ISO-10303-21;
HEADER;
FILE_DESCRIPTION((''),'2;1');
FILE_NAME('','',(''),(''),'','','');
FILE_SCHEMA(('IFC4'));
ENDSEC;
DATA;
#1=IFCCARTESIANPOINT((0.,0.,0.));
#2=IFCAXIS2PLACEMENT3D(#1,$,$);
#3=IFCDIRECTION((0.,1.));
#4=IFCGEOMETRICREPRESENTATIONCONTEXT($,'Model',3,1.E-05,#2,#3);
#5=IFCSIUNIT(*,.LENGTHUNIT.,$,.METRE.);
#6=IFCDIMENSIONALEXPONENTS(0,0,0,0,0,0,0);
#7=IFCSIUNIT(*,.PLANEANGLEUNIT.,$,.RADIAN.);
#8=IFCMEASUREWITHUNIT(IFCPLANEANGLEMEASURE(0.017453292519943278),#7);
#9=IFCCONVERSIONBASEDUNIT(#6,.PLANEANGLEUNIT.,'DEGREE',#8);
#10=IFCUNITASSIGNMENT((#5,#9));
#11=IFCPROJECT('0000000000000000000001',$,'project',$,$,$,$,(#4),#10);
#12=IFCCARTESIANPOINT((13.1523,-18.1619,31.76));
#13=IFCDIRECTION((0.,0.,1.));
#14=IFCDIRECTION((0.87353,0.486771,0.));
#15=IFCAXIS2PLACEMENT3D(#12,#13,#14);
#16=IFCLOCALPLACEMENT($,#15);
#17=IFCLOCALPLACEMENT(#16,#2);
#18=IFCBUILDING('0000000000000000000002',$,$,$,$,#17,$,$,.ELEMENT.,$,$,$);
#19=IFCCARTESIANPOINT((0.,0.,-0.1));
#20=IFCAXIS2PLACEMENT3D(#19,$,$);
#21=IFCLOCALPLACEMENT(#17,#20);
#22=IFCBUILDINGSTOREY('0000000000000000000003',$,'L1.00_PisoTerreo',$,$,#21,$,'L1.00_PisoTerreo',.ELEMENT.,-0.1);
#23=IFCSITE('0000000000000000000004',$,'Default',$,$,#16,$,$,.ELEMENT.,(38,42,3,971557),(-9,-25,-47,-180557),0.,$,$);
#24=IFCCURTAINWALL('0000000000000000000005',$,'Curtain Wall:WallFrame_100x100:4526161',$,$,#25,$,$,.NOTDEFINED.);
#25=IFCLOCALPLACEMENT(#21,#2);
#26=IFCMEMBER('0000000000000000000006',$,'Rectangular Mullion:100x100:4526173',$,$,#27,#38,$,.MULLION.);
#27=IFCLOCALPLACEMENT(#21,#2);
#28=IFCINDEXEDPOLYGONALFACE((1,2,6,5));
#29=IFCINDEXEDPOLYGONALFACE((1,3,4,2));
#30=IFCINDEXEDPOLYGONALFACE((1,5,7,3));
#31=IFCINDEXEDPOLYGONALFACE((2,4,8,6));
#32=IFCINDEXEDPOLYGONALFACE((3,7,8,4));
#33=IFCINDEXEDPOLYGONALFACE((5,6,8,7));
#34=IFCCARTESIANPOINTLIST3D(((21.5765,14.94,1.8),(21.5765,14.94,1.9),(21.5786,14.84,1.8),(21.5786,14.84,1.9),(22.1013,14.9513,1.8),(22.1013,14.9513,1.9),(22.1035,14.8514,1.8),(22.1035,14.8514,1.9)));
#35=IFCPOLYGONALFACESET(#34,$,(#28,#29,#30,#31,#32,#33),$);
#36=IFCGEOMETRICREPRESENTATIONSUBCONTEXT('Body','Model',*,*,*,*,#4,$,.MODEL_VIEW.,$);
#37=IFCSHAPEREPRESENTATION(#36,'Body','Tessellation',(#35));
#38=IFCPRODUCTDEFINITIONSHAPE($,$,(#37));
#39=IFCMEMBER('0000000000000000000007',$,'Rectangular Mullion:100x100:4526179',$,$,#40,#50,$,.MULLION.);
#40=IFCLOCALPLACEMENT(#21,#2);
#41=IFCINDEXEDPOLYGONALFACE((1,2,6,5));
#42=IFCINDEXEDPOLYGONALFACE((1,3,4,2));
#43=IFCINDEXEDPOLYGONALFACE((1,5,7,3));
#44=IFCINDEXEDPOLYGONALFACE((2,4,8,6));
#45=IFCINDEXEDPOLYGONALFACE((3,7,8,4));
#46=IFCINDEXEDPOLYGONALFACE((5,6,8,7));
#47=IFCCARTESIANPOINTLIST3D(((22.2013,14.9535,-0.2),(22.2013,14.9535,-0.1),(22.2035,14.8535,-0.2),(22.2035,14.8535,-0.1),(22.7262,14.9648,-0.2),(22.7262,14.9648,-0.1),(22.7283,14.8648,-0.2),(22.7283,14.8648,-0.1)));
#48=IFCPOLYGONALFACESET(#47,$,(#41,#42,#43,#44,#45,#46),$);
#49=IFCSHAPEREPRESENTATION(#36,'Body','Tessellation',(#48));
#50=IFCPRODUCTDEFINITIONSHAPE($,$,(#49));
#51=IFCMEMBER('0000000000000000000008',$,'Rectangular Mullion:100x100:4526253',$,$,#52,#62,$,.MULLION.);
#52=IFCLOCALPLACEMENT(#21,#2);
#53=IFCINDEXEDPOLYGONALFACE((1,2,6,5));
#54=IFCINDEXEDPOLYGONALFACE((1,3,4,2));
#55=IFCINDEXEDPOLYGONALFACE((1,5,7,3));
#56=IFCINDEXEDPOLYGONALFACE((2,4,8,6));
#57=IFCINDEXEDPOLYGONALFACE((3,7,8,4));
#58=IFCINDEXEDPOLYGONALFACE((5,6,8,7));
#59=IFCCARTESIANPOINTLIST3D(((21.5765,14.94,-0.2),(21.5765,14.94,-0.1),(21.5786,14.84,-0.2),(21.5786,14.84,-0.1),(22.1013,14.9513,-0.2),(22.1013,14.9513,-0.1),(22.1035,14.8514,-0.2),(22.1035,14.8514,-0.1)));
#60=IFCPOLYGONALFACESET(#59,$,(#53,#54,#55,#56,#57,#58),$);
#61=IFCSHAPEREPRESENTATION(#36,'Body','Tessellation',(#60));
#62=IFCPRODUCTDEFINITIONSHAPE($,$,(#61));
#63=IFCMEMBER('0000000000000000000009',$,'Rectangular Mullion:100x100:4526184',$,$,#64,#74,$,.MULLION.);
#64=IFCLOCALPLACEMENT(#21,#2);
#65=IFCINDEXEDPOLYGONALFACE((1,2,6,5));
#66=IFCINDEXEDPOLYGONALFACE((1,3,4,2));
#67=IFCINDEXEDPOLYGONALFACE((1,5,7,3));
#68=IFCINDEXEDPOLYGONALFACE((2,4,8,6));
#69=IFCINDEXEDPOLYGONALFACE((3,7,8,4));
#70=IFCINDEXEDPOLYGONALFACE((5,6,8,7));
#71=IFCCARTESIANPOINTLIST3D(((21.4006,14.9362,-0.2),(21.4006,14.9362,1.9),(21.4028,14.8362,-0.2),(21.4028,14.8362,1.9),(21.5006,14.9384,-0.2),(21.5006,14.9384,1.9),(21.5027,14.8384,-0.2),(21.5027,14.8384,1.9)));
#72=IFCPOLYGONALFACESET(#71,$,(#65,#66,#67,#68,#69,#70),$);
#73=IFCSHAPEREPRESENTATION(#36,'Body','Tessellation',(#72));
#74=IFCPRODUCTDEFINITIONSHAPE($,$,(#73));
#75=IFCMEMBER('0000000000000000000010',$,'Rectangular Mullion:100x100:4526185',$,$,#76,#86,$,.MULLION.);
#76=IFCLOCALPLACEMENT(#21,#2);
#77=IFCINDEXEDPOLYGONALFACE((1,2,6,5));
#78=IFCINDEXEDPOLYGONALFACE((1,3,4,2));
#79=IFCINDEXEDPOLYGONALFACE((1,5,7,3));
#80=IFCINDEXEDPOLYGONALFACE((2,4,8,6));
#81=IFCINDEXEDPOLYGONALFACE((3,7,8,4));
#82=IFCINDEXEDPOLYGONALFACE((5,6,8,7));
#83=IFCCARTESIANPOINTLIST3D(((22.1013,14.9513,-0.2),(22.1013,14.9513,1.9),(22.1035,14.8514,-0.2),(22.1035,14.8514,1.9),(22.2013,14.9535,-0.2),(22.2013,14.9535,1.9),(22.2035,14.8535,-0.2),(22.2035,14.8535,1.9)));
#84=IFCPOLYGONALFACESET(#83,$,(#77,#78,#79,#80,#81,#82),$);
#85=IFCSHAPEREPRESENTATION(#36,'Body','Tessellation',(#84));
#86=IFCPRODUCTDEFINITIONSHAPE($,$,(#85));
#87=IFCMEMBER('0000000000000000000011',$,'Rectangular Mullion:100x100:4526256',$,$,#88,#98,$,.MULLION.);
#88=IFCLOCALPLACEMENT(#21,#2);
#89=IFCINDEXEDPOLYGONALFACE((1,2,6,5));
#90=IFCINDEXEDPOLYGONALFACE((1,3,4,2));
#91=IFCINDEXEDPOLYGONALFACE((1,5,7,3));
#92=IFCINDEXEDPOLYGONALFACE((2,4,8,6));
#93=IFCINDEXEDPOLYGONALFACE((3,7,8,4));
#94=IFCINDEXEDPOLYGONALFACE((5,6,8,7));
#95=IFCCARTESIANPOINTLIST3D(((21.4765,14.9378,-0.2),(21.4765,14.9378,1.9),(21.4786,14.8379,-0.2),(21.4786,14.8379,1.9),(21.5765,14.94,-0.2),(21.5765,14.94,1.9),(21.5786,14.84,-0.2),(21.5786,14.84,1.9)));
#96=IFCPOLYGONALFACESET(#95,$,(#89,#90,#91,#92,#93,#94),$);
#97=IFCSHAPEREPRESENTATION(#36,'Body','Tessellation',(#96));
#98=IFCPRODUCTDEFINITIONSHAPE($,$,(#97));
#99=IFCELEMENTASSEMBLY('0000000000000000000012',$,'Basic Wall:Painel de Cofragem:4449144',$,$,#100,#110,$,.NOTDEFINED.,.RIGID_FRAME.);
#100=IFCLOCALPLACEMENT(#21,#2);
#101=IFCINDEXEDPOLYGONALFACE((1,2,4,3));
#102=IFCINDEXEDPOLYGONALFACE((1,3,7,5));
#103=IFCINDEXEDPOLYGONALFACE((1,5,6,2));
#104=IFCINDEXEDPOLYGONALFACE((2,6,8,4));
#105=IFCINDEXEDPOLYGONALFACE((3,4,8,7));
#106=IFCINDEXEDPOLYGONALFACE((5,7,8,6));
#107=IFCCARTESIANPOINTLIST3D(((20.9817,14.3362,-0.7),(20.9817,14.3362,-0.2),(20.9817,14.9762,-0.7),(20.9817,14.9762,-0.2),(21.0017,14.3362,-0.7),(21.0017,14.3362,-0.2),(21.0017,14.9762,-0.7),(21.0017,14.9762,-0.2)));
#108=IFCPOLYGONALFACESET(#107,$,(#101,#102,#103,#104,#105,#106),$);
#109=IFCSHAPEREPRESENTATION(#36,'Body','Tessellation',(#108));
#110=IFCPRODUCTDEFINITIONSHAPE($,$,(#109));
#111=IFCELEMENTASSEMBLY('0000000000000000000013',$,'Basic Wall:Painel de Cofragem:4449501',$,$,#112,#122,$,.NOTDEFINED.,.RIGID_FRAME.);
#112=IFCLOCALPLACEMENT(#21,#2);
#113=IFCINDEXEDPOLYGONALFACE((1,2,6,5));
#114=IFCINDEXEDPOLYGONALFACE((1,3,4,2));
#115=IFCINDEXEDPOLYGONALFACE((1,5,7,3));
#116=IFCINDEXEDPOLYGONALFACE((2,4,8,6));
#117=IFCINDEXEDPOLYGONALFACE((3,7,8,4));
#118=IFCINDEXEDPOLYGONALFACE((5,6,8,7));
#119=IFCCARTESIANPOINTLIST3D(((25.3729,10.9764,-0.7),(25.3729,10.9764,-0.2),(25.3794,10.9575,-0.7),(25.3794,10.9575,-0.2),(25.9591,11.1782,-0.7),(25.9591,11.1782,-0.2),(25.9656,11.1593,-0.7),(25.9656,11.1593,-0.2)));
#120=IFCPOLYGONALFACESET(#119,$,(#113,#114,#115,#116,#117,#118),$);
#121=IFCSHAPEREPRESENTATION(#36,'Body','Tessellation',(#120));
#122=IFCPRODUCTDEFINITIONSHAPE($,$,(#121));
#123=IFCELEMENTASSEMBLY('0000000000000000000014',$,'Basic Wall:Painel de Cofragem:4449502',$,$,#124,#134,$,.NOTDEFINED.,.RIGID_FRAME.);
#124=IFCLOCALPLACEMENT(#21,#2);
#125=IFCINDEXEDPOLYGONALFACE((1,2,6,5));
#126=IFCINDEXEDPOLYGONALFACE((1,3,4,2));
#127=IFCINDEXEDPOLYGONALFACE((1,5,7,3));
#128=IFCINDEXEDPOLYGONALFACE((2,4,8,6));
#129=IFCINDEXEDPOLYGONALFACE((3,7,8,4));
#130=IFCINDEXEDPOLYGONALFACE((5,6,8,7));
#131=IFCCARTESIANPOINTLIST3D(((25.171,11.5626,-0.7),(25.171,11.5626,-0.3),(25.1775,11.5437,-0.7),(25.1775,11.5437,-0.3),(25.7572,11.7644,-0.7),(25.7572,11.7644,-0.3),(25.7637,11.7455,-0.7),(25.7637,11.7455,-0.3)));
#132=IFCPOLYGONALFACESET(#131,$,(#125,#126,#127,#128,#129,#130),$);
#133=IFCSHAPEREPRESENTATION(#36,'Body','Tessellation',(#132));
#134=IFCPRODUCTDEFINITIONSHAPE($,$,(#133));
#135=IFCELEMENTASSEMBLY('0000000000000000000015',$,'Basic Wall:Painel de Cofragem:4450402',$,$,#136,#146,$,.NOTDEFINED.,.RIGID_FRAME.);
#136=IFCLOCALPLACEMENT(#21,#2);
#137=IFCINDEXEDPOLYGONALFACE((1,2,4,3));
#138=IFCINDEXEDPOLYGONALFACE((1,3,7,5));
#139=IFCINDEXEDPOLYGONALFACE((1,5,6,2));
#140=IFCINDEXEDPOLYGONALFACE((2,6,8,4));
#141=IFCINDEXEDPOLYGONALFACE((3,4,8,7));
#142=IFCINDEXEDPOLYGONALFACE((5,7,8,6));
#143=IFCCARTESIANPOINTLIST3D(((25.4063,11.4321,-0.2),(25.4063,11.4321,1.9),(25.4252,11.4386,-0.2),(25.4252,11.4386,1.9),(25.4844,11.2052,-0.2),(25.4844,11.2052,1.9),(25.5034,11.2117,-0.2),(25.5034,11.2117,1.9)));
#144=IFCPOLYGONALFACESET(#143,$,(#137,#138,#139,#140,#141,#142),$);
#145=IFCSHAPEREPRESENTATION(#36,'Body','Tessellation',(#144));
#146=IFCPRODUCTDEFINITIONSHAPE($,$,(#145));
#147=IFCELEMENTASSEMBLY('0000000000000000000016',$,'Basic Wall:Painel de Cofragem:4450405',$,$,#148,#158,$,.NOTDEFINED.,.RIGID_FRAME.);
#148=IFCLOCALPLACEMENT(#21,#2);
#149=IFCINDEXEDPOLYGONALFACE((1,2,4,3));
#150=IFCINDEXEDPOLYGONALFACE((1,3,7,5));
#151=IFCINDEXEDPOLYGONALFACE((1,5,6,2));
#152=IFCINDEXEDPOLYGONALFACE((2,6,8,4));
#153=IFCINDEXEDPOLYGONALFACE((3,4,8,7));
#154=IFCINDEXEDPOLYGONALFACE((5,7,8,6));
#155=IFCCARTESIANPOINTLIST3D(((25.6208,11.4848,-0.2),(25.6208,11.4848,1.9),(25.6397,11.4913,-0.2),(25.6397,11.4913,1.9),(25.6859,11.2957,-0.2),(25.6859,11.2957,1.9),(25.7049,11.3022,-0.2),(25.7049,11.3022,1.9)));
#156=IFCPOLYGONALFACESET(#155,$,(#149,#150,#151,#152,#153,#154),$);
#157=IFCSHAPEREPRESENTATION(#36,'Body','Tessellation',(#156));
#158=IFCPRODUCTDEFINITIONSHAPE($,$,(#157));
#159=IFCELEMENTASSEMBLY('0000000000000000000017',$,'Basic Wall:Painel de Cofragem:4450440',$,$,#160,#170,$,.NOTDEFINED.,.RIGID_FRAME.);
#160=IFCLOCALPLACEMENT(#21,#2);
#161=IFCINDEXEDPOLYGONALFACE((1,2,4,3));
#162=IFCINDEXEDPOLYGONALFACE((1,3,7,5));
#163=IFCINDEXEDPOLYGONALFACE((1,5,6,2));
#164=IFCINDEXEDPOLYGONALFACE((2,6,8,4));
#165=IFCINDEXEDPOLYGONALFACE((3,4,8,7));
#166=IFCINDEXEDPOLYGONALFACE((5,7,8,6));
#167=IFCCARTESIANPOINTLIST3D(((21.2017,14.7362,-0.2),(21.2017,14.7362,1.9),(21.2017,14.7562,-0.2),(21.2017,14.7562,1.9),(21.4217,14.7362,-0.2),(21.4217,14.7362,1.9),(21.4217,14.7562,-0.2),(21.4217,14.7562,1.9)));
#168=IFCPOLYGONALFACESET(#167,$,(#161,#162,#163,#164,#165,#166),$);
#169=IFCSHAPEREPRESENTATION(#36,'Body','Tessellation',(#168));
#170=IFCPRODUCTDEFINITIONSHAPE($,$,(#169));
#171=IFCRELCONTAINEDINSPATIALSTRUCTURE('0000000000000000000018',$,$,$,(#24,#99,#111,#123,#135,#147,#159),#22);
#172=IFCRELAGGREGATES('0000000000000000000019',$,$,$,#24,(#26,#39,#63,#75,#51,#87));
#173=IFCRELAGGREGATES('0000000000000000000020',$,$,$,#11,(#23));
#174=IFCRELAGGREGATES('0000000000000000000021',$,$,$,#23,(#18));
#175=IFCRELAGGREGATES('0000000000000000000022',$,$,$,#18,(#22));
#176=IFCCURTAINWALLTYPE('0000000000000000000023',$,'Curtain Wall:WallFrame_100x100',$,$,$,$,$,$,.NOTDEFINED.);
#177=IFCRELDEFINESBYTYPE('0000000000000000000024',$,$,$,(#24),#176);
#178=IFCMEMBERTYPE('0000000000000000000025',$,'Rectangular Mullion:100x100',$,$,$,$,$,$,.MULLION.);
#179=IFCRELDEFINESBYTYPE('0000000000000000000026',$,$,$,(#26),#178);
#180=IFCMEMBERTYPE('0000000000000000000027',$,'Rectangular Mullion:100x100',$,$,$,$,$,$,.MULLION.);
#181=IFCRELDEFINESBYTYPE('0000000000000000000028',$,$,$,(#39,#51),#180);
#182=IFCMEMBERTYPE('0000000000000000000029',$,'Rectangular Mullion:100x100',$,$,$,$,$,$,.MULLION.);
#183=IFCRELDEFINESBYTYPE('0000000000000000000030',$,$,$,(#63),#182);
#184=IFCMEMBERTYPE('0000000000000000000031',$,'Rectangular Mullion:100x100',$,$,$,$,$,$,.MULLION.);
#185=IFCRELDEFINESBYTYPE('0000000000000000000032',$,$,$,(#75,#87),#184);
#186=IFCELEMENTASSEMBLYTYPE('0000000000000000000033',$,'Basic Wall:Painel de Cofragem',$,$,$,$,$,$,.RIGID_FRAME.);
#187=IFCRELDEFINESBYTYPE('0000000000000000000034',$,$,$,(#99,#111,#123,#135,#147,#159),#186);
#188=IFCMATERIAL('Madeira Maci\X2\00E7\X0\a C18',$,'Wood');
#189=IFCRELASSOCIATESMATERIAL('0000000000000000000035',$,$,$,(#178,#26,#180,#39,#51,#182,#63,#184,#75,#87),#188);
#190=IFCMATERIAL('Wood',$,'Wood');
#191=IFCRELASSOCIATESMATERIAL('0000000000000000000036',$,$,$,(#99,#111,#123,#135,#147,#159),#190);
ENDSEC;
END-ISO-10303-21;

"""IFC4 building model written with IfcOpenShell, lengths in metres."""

from ifc_helpers import new_model, entity, si_unit, converted_unit, direction, frame, origin, place, context, subcontext, project, spatial, indexed_curve, outline, extrude, source, transform, mapped, material, type_object, type_shapes, element, aggregate, save


model = new_model("IFC4")

# Units and contexts
model_context = context("Model", 3, precision=1e-05, world=origin(), true_north=direction((0.0, 1.0)))
body_context = subcontext(model_context, "Body", "Model", "MODEL_VIEW")
ifc_project = project(units=[si_unit("LENGTHUNIT", "METRE"), converted_unit("PLANEANGLEUNIT", "DEGREE", entity("IfcPlaneAngleMeasure", 0.017453292519943278), si_unit("PLANEANGLEUNIT", "RADIAN"), dimensions=[0, 0, 0, 0, 0, 0, 0])], contexts=[model_context])

# Site, building, storey
site_placement = place(None, frame((13.1523, -18.1619, 31.76), z_axis=(0.0, 0.0, 1.0), x_axis=(0.87353, 0.486771, 0.0)))
site = spatial("IfcSite", under=ifc_project, at=site_placement, Name="Default", CompositionType="ELEMENT", RefLatitude=(38, 42, 3, 971557), RefLongitude=(-9, -25, -47, -180557), RefElevation=0.0)
building_placement = place(site_placement, origin())
building = spatial("IfcBuilding", under=site, at=building_placement, CompositionType="ELEMENT")
storey_placement = place(building_placement, frame((0.0, 0.0, -0.1)))
storey = spatial("IfcBuildingStorey", under=building, at=storey_placement, Name="L1.00_PisoTerreo", LongName="L1.00_PisoTerreo", CompositionType="ELEMENT", Elevation=-0.1)

# Curtain wall, members
curtain_wall_type = type_object("IfcCurtainWallType", Name="Curtain Wall:WallFrame_100x100", PredefinedType="NOTDEFINED")
curtain_wall_placement = place(storey_placement, frame((0.0, 0.0, 0.1)))
curtain_wall = element("IfcCurtainWall", 1, at=curtain_wall_placement, inside=storey, type_object=curtain_wall_type, Name="Curtain Wall:WallFrame_100x100:4526161", PredefinedType="NOTDEFINED")
ifc_material_1 = material(Name="Madeira Maciça C18", Category="Wood")
member_type_1 = type_object("IfcMemberType", Name="Rectangular Mullion:100x100", PredefinedType="MULLION", material=ifc_material_1)
shared_shape_1 = source(origin(), body_context, "Body", "SweptSolid", [
    extrude(outline(indexed_curve([(-0.05, -0.05), (0.05, -0.05), (0.05, 0.05), (-0.05, 0.05), (-0.05, -0.05)], self_intersect=False)), frame((-0.05, 0.0, -0.525), z_axis=(0.0, 0.0, 1.0), x_axis=(-1.0, 0.0, 0.0)), (0.0, 0.0, 1.0), 0.525),
])
type_shapes(member_type_1, [shared_shape_1])
member_1_placement = place(curtain_wall_placement, frame((22.1024, 14.9013, 1.8), z_axis=(0.999767, 0.021581, 0.0), x_axis=(0.0, 0.0, 1.0)))
member_1 = element("IfcMember", 2, at=member_1_placement, type_object=member_type_1, material=ifc_material_1, Name="Rectangular Mullion:100x100:4526173", PredefinedType="MULLION", context=body_context, shape_type="MappedRepresentation", body=[
    mapped(shared_shape_1, transform((0.0, 0.0, 0.0), scale=1.0)),
])
member_type_2 = type_object("IfcMemberType", Name="Rectangular Mullion:100x100", PredefinedType="MULLION", material=ifc_material_1)
shared_shape_2 = source(origin(), body_context, "Body", "SweptSolid", [
    extrude(outline(indexed_curve([(-0.05, -0.05), (0.05, -0.05), (0.05, 0.05), (-0.05, 0.05), (-0.05, -0.05)], self_intersect=False)), frame((-0.05, 0.0, -0.525), z_axis=(0.0, 0.0, 1.0), x_axis=(0.0, -1.0, 0.0)), (0.0, 0.0, 1.0), 0.525),
])
type_shapes(member_type_2, [shared_shape_2])
member_2_placement = place(curtain_wall_placement, frame((22.2024, 14.9035, -0.3), z_axis=(-0.999767, -0.021581, 0.0), x_axis=(0.0, 0.0, -1.0)))
member_2 = element("IfcMember", 3, at=member_2_placement, type_object=member_type_2, material=ifc_material_1, Name="Rectangular Mullion:100x100:4526179", PredefinedType="MULLION", context=body_context, shape_type="MappedRepresentation", body=[
    mapped(shared_shape_2, transform((0.0, 0.0, 0.0), scale=1.0)),
])
member_3_placement = place(curtain_wall_placement, frame((21.5775, 14.89, -0.3), z_axis=(-0.999767, -0.021581, 0.0), x_axis=(0.0, 0.0, -1.0)))
member_3 = element("IfcMember", 4, at=member_3_placement, type_object=member_type_2, material=ifc_material_1, Name="Rectangular Mullion:100x100:4526253", PredefinedType="MULLION", context=body_context, shape_type="MappedRepresentation", body=[
    mapped(shared_shape_2, transform((0.0, 0.0, 0.0), scale=1.0)),
])
member_type_3 = type_object("IfcMemberType", Name="Rectangular Mullion:100x100", PredefinedType="MULLION", material=ifc_material_1)
shared_shape_3 = source(origin(), body_context, "Body", "SweptSolid", [
    extrude(outline(indexed_curve([(-0.05, -0.05), (0.05, -0.05), (0.05, 0.05), (-0.05, 0.05), (-0.05, -0.05)], self_intersect=False)), frame((-0.05, 0.0, -2.1), z_axis=(0.0, 0.0, 1.0), x_axis=(0.0, -1.0, 0.0)), (0.0, 0.0, 1.0), 2.1),
])
type_shapes(member_type_3, [shared_shape_3])
member_4_placement = place(curtain_wall_placement, frame((21.4017, 14.8862, 1.8), z_axis=(0.0, 0.0, 1.0), x_axis=(-0.999767, -0.021581, 0.0)))
member_4 = element("IfcMember", 5, at=member_4_placement, type_object=member_type_3, material=ifc_material_1, Name="Rectangular Mullion:100x100:4526184", PredefinedType="MULLION", context=body_context, shape_type="MappedRepresentation", body=[
    mapped(shared_shape_3, transform((0.0, 0.0, 0.0), scale=1.0)),
])
member_type_4 = type_object("IfcMemberType", Name="Rectangular Mullion:100x100", PredefinedType="MULLION", material=ifc_material_1)
shared_shape_4 = source(origin(), body_context, "Body", "SweptSolid", [
    extrude(outline(indexed_curve([(-0.05, -0.05), (0.05, -0.05), (0.05, 0.05), (-0.05, 0.05), (-0.05, -0.05)], self_intersect=False)), frame((0.0, 0.0, -2.1), z_axis=(0.0, 0.0, 1.0), x_axis=(-1.0, 0.0, 0.0)), (0.0, 0.0, 1.0), 2.1),
])
type_shapes(member_type_4, [shared_shape_4])
member_5_placement = place(curtain_wall_placement, frame((22.1524, 14.9024, -0.3), z_axis=(0.0, 0.0, -1.0), x_axis=(0.999767, 0.021581, 0.0)))
member_5 = element("IfcMember", 6, at=member_5_placement, type_object=member_type_4, material=ifc_material_1, Name="Rectangular Mullion:100x100:4526185", PredefinedType="MULLION", context=body_context, shape_type="MappedRepresentation", body=[
    mapped(shared_shape_4, transform((0.0, 0.0, 0.0), scale=1.0)),
])
member_6_placement = place(curtain_wall_placement, frame((21.5275, 14.8889, -0.3), z_axis=(0.0, 0.0, -1.0), x_axis=(0.999767, 0.021581, 0.0)))
member_6 = element("IfcMember", 7, at=member_6_placement, type_object=member_type_4, material=ifc_material_1, Name="Rectangular Mullion:100x100:4526256", PredefinedType="MULLION", context=body_context, shape_type="MappedRepresentation", body=[
    mapped(shared_shape_4, transform((0.0, 0.0, 0.0), scale=1.0)),
])
aggregate(curtain_wall, [member_1, member_2, member_4, member_5, member_3, member_6])

# Element assemblies
ifc_material_2 = material(Name="Wood", Category="Wood")
element_assembly_type = type_object("IfcElementAssemblyType", Name="Basic Wall:Painel de Cofragem", PredefinedType="RIGID_FRAME")
assembly_1_placement = place(storey_placement, frame((20.9917, 14.3362, -0.7), z_axis=(0.0, 0.0, 1.0), x_axis=(0.0, 1.0, 0.0)))
element("IfcElementAssembly", 8, at=assembly_1_placement, inside=storey, type_object=element_assembly_type, material=ifc_material_2, Name="Basic Wall:Painel de Cofragem:4449144", AssemblyPlace="NOTDEFINED", PredefinedType="RIGID_FRAME", context=body_context, shape_type="SweptSolid", body=[
    extrude(outline(indexed_curve([(0.64, 0.01), (0.0, 0.01), (0.0, -0.01), (0.64, -0.01), (0.64, 0.01)], self_intersect=False)), origin(), (0.0, 0.0, 1.0), 0.5),
])
assembly_2_placement = place(storey_placement, frame((25.3761, 10.9669, -0.7), z_axis=(0.0, 0.0, 1.0), x_axis=(0.945519, 0.325568, 0.0)))
element("IfcElementAssembly", 9, at=assembly_2_placement, inside=storey, type_object=element_assembly_type, material=ifc_material_2, Name="Basic Wall:Painel de Cofragem:4449501", AssemblyPlace="NOTDEFINED", PredefinedType="RIGID_FRAME", context=body_context, shape_type="SweptSolid", body=[
    extrude(outline(indexed_curve([(0.62, 0.01), (0.0, 0.01), (0.0, -0.01), (0.62, -0.01), (0.62, 0.01)], self_intersect=False)), origin(), (0.0, 0.0, 1.0), 0.5),
])
assembly_3_placement = place(storey_placement, frame((25.1743, 11.5531, -0.7), z_axis=(0.0, 0.0, 1.0), x_axis=(0.945519, 0.325568, 0.0)))
element("IfcElementAssembly", 10, at=assembly_3_placement, inside=storey, type_object=element_assembly_type, material=ifc_material_2, Name="Basic Wall:Painel de Cofragem:4449502", AssemblyPlace="NOTDEFINED", PredefinedType="RIGID_FRAME", context=body_context, shape_type="SweptSolid", body=[
    extrude(outline(indexed_curve([(0.62, 0.01), (0.0, 0.01), (0.0, -0.01), (0.62, -0.01), (0.62, 0.01)], self_intersect=False)), origin(), (0.0, 0.0, 1.0), 0.4),
])
assembly_4_placement = place(storey_placement, frame((25.4158, 11.4353, -0.2), z_axis=(0.0, 0.0, 1.0), x_axis=(0.325568, -0.945519, 0.0)))
element("IfcElementAssembly", 11, at=assembly_4_placement, inside=storey, type_object=element_assembly_type, material=ifc_material_2, Name="Basic Wall:Painel de Cofragem:4450402", AssemblyPlace="NOTDEFINED", PredefinedType="RIGID_FRAME", context=body_context, shape_type="SweptSolid", body=[
    extrude(outline(indexed_curve([(0.24, 0.01), (0.0, 0.01), (0.0, -0.01), (0.24, -0.01), (0.24, 0.01)], self_intersect=False)), origin(), (0.0, 0.0, 1.0), 2.1),
])
assembly_5_placement = place(storey_placement, frame((25.6303, 11.4881, -0.2), z_axis=(0.0, 0.0, 1.0), x_axis=(0.325568, -0.945519, 0.0)))
element("IfcElementAssembly", 12, at=assembly_5_placement, inside=storey, type_object=element_assembly_type, material=ifc_material_2, Name="Basic Wall:Painel de Cofragem:4450405", AssemblyPlace="NOTDEFINED", PredefinedType="RIGID_FRAME", context=body_context, shape_type="SweptSolid", body=[
    extrude(outline(indexed_curve([(0.2, 0.01), (0.0, 0.01), (0.0, -0.01), (0.2, -0.01), (0.2, 0.01)], self_intersect=False)), origin(), (0.0, 0.0, 1.0), 2.1),
])
assembly_6_placement = place(storey_placement, frame((21.4217, 14.7462, -0.2), z_axis=(0.0, 0.0, 1.0), x_axis=(-1.0, 0.0, 0.0)))
element("IfcElementAssembly", 13, at=assembly_6_placement, inside=storey, type_object=element_assembly_type, material=ifc_material_2, Name="Basic Wall:Painel de Cofragem:4450440", AssemblyPlace="NOTDEFINED", PredefinedType="RIGID_FRAME", context=body_context, shape_type="SweptSolid", body=[
    extrude(outline(indexed_curve([(0.22, 0.01), (0.0, 0.01), (0.0, -0.01), (0.22, -0.01), (0.22, 0.01)], self_intersect=False)), origin(), (0.0, 0.0, 1.0), 2.1),
])

save(model, "model.ifc")
